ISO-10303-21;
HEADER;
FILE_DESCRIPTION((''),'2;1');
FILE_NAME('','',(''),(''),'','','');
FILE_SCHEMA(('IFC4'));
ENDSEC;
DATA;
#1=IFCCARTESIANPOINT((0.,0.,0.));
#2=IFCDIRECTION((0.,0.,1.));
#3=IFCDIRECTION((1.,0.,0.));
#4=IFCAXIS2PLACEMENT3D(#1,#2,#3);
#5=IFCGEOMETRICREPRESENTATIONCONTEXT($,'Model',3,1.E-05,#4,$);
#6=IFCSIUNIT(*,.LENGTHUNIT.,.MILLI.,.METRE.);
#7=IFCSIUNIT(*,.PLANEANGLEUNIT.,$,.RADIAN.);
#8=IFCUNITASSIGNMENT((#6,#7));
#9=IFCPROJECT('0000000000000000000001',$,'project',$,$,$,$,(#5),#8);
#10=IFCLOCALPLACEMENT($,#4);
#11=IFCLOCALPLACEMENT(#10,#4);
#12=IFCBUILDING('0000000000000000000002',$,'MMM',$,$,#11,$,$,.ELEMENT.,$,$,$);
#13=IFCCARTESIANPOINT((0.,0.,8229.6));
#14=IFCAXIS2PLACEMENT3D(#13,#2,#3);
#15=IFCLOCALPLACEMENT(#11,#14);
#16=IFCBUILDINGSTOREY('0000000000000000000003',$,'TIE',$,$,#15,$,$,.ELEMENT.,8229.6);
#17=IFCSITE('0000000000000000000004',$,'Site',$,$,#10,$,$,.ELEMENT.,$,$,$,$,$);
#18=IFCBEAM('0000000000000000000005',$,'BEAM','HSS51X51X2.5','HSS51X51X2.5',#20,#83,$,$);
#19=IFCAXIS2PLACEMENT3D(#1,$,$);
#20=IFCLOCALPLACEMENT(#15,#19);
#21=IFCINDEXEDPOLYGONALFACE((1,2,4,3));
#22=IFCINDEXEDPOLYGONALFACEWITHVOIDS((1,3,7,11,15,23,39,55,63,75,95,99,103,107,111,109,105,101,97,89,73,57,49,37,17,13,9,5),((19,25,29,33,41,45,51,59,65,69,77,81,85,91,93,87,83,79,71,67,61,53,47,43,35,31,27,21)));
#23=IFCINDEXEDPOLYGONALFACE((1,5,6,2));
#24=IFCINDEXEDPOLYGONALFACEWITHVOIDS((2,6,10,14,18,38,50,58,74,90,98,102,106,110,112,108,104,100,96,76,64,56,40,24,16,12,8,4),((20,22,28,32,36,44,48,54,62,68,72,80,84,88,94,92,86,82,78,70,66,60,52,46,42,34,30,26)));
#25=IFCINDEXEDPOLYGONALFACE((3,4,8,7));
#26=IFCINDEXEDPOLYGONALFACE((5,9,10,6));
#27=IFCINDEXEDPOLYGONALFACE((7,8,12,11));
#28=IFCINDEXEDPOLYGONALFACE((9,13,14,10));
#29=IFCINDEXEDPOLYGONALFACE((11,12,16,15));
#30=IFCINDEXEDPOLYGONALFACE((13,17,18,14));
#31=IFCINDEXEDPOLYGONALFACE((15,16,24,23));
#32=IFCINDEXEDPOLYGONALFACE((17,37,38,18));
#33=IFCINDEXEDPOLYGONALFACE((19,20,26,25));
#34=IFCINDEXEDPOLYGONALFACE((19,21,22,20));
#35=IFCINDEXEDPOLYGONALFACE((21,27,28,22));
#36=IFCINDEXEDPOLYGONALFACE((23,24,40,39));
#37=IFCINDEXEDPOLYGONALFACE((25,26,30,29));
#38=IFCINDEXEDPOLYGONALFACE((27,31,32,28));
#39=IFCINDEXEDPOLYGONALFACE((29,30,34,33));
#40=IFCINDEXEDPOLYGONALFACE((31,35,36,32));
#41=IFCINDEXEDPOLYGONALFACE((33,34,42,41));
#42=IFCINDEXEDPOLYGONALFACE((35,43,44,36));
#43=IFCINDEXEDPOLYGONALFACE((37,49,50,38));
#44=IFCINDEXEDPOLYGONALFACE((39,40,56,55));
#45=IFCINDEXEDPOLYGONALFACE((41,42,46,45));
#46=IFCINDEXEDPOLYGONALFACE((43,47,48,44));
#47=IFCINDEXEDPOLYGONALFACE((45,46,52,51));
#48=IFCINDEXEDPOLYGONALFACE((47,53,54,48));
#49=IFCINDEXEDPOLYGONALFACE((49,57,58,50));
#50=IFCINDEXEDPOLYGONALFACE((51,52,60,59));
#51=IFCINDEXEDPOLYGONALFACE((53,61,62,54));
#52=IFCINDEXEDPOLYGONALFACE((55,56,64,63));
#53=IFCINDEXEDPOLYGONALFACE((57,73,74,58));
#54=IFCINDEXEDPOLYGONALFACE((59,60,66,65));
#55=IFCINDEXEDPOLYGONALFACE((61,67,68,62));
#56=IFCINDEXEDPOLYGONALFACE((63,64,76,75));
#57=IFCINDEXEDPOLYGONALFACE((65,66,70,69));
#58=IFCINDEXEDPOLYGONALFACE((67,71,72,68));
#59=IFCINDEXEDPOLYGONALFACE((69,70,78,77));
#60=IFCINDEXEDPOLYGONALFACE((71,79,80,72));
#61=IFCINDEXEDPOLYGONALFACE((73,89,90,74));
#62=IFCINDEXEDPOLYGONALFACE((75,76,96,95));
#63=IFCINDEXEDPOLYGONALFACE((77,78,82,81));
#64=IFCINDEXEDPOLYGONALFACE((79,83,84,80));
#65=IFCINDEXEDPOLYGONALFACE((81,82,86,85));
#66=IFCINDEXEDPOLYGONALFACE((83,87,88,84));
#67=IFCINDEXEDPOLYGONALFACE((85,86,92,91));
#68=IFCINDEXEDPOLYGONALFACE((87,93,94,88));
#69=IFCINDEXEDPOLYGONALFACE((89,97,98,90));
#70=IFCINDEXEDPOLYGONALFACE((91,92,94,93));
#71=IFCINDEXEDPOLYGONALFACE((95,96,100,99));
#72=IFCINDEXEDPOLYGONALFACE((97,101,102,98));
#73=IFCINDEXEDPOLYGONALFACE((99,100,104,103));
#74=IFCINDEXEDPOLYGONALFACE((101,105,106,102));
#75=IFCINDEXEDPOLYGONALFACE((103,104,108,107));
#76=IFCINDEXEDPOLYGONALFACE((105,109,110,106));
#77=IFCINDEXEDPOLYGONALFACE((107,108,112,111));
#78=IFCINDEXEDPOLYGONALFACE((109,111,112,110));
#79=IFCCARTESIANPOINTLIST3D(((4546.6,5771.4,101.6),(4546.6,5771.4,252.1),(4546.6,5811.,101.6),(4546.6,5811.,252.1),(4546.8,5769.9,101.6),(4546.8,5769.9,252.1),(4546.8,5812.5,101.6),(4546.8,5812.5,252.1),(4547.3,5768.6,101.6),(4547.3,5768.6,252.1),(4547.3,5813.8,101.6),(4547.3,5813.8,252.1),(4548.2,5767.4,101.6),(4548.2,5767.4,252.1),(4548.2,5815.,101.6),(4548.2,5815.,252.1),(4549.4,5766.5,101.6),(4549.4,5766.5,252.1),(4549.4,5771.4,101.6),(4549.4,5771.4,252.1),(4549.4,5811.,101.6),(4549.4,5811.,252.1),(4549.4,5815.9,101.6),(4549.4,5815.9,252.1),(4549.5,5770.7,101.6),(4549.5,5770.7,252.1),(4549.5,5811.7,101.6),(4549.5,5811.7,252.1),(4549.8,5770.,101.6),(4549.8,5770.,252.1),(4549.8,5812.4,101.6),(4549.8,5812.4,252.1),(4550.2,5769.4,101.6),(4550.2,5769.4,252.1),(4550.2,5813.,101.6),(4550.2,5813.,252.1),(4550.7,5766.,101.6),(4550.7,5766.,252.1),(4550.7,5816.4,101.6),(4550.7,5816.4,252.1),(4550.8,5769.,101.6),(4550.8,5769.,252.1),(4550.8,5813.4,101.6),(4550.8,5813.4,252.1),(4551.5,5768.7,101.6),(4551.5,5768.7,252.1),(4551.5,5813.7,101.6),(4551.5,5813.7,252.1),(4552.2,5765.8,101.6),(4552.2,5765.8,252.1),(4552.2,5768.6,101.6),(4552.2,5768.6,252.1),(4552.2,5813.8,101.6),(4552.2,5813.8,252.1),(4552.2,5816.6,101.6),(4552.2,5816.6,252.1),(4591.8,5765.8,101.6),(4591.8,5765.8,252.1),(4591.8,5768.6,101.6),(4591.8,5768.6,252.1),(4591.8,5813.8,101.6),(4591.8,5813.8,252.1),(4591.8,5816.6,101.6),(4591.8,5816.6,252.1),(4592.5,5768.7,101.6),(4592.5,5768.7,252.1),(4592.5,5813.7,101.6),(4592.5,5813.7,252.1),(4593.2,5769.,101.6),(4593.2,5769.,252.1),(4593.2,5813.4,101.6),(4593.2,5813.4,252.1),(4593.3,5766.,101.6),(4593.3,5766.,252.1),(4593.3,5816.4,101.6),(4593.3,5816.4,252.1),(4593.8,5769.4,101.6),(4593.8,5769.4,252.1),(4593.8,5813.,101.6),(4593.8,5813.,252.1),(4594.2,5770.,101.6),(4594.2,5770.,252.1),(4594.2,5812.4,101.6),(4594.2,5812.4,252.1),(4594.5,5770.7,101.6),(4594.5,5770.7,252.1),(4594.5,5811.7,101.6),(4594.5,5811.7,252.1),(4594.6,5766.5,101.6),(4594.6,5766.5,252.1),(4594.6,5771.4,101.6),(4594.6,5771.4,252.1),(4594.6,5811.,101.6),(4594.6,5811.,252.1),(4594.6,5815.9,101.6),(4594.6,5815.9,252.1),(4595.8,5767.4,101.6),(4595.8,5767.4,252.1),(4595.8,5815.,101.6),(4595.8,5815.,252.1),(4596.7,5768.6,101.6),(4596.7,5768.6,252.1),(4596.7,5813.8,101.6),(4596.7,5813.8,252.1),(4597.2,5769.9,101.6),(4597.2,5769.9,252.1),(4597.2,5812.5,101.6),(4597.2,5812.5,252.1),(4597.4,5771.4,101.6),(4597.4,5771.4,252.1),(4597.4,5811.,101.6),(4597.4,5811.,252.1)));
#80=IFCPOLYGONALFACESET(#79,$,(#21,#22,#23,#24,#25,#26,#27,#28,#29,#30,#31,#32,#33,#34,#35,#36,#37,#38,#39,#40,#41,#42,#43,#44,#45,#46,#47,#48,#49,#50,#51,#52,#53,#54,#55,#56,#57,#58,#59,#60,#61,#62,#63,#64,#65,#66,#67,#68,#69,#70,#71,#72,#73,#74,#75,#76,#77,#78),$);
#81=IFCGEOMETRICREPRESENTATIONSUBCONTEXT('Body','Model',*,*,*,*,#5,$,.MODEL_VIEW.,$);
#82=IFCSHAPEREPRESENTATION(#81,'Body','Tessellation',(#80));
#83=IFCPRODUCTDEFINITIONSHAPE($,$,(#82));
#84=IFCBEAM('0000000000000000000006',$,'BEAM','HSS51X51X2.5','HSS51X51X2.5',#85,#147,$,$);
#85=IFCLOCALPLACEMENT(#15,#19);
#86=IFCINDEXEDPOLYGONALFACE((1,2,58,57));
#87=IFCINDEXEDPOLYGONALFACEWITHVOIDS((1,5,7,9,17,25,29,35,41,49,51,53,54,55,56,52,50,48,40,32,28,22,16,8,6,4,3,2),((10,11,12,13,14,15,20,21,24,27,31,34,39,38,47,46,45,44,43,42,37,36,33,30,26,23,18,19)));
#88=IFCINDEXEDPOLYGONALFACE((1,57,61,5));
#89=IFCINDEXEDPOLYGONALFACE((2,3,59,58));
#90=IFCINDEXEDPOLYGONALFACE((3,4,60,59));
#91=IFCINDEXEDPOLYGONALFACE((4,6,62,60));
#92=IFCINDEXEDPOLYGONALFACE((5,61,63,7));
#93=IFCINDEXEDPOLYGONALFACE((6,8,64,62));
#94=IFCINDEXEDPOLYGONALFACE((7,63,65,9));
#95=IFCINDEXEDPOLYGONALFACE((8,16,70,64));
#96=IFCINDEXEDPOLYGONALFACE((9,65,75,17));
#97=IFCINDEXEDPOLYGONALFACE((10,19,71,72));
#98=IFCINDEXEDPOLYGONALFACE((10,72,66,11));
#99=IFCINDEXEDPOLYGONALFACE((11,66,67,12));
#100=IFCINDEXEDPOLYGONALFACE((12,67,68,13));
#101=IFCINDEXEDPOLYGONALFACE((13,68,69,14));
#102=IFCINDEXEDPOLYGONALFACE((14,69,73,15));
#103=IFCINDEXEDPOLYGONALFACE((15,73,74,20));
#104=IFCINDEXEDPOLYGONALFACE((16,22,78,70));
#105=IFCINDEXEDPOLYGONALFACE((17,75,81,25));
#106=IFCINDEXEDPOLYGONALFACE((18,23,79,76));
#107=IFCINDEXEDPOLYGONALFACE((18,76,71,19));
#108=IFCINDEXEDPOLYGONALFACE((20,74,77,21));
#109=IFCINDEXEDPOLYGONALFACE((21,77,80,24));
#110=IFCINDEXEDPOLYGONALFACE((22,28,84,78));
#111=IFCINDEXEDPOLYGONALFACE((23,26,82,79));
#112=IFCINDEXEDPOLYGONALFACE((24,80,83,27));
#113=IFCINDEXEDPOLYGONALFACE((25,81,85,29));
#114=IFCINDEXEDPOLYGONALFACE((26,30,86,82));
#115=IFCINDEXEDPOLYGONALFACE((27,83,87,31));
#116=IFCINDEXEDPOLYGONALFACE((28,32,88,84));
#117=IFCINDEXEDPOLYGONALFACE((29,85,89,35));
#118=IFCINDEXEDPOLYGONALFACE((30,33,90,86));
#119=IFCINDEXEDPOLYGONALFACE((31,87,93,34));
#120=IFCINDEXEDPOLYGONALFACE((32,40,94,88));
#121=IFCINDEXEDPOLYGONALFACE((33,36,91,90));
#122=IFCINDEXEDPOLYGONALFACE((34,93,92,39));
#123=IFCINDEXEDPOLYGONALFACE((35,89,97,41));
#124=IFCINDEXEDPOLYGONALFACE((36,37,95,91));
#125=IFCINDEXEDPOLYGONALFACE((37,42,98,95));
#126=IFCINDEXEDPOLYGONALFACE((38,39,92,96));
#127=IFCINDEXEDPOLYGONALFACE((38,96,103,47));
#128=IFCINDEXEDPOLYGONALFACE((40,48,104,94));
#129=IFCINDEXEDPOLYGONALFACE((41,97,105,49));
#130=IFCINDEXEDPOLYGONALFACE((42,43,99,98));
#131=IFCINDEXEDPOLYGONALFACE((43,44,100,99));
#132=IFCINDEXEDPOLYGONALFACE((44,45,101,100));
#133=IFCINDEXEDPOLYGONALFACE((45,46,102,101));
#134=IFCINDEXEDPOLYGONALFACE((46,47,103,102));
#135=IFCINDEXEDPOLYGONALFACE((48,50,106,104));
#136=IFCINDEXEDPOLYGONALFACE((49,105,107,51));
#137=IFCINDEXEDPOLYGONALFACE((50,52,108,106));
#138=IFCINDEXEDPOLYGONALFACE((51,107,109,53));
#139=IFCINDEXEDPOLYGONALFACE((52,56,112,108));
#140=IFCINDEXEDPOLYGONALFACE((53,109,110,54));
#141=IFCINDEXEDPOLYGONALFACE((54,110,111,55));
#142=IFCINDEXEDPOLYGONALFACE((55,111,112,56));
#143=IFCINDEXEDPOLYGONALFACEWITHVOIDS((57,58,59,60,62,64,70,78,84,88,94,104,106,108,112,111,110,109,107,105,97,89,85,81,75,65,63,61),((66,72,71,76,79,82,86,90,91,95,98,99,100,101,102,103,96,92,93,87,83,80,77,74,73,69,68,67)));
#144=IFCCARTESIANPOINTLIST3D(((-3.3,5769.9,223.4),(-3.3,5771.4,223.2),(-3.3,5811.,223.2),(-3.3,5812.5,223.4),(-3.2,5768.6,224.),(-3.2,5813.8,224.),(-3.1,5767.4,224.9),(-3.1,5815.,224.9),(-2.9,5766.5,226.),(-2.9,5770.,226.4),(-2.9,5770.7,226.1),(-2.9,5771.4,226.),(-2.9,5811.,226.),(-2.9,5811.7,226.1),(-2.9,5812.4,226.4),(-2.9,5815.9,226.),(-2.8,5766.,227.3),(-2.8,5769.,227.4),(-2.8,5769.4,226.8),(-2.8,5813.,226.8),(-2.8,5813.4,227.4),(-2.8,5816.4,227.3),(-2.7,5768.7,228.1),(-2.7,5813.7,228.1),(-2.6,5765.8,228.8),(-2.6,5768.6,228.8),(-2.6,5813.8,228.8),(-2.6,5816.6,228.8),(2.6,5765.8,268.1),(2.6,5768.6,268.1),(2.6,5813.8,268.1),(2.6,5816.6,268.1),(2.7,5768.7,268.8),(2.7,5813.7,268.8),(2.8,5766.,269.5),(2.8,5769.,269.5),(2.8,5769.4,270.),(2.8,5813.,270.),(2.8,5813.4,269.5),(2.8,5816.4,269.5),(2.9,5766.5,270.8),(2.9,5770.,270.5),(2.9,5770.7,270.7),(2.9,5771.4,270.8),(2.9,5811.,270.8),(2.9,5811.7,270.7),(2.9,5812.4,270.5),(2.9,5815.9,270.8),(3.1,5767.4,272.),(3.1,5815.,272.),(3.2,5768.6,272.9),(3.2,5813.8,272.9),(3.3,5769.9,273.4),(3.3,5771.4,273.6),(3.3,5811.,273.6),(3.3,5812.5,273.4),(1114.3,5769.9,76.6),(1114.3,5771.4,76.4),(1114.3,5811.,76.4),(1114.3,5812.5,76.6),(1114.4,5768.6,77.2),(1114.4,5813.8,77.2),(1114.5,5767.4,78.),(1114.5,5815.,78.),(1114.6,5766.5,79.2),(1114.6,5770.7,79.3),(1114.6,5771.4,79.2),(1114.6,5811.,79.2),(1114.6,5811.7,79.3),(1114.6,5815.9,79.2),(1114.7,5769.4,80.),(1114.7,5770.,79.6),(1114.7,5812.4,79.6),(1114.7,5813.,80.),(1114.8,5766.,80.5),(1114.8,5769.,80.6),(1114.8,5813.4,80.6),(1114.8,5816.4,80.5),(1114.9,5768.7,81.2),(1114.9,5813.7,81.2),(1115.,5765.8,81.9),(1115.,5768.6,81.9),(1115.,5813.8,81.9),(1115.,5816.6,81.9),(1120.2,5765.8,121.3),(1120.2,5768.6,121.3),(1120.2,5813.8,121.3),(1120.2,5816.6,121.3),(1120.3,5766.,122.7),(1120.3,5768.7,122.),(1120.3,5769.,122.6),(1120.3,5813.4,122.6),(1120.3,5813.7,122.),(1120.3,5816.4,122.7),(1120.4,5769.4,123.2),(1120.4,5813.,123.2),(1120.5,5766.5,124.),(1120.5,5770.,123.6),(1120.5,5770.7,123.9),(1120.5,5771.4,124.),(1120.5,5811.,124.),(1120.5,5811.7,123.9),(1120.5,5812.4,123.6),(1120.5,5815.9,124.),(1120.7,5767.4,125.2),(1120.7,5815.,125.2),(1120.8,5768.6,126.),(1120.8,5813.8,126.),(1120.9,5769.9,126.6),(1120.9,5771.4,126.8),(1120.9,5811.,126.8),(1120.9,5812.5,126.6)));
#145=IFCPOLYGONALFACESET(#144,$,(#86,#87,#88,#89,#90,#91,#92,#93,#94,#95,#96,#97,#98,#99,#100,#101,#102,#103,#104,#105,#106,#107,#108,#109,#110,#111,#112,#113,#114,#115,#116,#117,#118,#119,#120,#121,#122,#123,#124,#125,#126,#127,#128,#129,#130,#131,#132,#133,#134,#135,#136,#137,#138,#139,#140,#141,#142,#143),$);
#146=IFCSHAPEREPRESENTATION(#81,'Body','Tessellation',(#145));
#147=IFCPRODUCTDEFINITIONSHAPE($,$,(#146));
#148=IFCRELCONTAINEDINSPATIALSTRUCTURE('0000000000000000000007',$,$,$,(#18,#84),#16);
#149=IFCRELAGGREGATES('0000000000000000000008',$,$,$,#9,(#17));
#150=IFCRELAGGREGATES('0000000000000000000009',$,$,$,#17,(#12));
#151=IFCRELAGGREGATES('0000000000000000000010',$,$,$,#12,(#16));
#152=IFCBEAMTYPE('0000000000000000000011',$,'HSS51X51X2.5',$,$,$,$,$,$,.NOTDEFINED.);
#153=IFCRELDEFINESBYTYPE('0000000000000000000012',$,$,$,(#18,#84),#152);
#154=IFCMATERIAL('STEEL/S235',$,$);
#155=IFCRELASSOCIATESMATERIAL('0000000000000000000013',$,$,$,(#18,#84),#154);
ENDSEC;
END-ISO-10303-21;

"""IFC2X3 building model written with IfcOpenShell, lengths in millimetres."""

from ifc_helpers import new_model, si_unit, frame, origin_with_axes, origin_2d_with_axis, place, context, subcontext, project, spatial, hollow_rectangle, extrude, material, type_object, element, save


model = new_model("IFC2X3")

# Units and contexts
model_context = context("Model", 3, precision=1e-05, world=origin_with_axes())
body_context = subcontext(model_context, "Body", "Model", "MODEL_VIEW")
ifc_project = project(units=[si_unit("LENGTHUNIT", "METRE", prefix="MILLI"), si_unit("PLANEANGLEUNIT", "RADIAN")], contexts=[model_context])

# Site, building, storey
site_placement = place(None, origin_with_axes())
site = spatial("IfcSite", under=ifc_project, at=site_placement, Name="Site", CompositionType="ELEMENT")
building_placement = place(site_placement, origin_with_axes())
building = spatial("IfcBuilding", under=site, at=building_placement, Name="MMM", CompositionType="ELEMENT")
storey_placement = place(building_placement, frame((0.0, 0.0, 8229.6), z_axis=(0.0, 0.0, 1.0), x_axis=(1.0, 0.0, 0.0)))
storey = spatial("IfcBuildingStorey", under=building, at=storey_placement, Name="TIE", CompositionType="ELEMENT", Elevation=8229.6)

# Beams
ifc_material = material(Name="STEEL/S235")
beam_type_1 = type_object("IfcBeamType", Name="HSS51X51X2.5", PredefinedType="NOTDEFINED")
beam_1_placement = place(storey_placement, frame((4572.0, 5791.2, 252.1), z_axis=(-1.0, 0.0, 0.0), x_axis=(0.0, 0.0, -1.0)))
element("IfcBeam", 1, at=beam_1_placement, inside=storey, type_object=beam_type_1, material=ifc_material, Name="BEAM", Description="HSS51X51X2.5", ObjectType="HSS51X51X2.5", context=body_context, shape_type="SweptSolid", body=[
    extrude(hollow_rectangle(XDim=50.8, YDim=50.8, WallThickness=2.8, InnerFilletRadius=2.8, OuterFilletRadius=5.6, at=origin_2d_with_axis()), frame((150.5, 0.0, 0.0), z_axis=(-1.0, 0.0, 0.0), x_axis=(0.0, -1.0, 0.0)), (0.0, 0.0, 1.0), 150.5),
])
beam_2_placement = place(storey_placement, frame((1117.6, 5791.2, 101.6), z_axis=(0.130258, 0.0, 0.99148), x_axis=(-0.99148, 0.0, 0.130258)))
element("IfcBeam", 2, at=beam_2_placement, inside=storey, type_object=beam_type_1, material=ifc_material, Name="BEAM", Description="HSS51X51X2.5", ObjectType="HSS51X51X2.5", context=body_context, shape_type="SweptSolid", body=[
    extrude(hollow_rectangle(XDim=50.8, YDim=50.8, WallThickness=2.8, InnerFilletRadius=2.8, OuterFilletRadius=5.6, at=origin_2d_with_axis()), frame((1127.2, 0.0, 0.0), z_axis=(-1.0, 0.0, 0.0), x_axis=(0.0, -1.0, 0.0)), (0.0, 0.0, 1.0), 1127.2),
])

save(model, "model.ifc")
